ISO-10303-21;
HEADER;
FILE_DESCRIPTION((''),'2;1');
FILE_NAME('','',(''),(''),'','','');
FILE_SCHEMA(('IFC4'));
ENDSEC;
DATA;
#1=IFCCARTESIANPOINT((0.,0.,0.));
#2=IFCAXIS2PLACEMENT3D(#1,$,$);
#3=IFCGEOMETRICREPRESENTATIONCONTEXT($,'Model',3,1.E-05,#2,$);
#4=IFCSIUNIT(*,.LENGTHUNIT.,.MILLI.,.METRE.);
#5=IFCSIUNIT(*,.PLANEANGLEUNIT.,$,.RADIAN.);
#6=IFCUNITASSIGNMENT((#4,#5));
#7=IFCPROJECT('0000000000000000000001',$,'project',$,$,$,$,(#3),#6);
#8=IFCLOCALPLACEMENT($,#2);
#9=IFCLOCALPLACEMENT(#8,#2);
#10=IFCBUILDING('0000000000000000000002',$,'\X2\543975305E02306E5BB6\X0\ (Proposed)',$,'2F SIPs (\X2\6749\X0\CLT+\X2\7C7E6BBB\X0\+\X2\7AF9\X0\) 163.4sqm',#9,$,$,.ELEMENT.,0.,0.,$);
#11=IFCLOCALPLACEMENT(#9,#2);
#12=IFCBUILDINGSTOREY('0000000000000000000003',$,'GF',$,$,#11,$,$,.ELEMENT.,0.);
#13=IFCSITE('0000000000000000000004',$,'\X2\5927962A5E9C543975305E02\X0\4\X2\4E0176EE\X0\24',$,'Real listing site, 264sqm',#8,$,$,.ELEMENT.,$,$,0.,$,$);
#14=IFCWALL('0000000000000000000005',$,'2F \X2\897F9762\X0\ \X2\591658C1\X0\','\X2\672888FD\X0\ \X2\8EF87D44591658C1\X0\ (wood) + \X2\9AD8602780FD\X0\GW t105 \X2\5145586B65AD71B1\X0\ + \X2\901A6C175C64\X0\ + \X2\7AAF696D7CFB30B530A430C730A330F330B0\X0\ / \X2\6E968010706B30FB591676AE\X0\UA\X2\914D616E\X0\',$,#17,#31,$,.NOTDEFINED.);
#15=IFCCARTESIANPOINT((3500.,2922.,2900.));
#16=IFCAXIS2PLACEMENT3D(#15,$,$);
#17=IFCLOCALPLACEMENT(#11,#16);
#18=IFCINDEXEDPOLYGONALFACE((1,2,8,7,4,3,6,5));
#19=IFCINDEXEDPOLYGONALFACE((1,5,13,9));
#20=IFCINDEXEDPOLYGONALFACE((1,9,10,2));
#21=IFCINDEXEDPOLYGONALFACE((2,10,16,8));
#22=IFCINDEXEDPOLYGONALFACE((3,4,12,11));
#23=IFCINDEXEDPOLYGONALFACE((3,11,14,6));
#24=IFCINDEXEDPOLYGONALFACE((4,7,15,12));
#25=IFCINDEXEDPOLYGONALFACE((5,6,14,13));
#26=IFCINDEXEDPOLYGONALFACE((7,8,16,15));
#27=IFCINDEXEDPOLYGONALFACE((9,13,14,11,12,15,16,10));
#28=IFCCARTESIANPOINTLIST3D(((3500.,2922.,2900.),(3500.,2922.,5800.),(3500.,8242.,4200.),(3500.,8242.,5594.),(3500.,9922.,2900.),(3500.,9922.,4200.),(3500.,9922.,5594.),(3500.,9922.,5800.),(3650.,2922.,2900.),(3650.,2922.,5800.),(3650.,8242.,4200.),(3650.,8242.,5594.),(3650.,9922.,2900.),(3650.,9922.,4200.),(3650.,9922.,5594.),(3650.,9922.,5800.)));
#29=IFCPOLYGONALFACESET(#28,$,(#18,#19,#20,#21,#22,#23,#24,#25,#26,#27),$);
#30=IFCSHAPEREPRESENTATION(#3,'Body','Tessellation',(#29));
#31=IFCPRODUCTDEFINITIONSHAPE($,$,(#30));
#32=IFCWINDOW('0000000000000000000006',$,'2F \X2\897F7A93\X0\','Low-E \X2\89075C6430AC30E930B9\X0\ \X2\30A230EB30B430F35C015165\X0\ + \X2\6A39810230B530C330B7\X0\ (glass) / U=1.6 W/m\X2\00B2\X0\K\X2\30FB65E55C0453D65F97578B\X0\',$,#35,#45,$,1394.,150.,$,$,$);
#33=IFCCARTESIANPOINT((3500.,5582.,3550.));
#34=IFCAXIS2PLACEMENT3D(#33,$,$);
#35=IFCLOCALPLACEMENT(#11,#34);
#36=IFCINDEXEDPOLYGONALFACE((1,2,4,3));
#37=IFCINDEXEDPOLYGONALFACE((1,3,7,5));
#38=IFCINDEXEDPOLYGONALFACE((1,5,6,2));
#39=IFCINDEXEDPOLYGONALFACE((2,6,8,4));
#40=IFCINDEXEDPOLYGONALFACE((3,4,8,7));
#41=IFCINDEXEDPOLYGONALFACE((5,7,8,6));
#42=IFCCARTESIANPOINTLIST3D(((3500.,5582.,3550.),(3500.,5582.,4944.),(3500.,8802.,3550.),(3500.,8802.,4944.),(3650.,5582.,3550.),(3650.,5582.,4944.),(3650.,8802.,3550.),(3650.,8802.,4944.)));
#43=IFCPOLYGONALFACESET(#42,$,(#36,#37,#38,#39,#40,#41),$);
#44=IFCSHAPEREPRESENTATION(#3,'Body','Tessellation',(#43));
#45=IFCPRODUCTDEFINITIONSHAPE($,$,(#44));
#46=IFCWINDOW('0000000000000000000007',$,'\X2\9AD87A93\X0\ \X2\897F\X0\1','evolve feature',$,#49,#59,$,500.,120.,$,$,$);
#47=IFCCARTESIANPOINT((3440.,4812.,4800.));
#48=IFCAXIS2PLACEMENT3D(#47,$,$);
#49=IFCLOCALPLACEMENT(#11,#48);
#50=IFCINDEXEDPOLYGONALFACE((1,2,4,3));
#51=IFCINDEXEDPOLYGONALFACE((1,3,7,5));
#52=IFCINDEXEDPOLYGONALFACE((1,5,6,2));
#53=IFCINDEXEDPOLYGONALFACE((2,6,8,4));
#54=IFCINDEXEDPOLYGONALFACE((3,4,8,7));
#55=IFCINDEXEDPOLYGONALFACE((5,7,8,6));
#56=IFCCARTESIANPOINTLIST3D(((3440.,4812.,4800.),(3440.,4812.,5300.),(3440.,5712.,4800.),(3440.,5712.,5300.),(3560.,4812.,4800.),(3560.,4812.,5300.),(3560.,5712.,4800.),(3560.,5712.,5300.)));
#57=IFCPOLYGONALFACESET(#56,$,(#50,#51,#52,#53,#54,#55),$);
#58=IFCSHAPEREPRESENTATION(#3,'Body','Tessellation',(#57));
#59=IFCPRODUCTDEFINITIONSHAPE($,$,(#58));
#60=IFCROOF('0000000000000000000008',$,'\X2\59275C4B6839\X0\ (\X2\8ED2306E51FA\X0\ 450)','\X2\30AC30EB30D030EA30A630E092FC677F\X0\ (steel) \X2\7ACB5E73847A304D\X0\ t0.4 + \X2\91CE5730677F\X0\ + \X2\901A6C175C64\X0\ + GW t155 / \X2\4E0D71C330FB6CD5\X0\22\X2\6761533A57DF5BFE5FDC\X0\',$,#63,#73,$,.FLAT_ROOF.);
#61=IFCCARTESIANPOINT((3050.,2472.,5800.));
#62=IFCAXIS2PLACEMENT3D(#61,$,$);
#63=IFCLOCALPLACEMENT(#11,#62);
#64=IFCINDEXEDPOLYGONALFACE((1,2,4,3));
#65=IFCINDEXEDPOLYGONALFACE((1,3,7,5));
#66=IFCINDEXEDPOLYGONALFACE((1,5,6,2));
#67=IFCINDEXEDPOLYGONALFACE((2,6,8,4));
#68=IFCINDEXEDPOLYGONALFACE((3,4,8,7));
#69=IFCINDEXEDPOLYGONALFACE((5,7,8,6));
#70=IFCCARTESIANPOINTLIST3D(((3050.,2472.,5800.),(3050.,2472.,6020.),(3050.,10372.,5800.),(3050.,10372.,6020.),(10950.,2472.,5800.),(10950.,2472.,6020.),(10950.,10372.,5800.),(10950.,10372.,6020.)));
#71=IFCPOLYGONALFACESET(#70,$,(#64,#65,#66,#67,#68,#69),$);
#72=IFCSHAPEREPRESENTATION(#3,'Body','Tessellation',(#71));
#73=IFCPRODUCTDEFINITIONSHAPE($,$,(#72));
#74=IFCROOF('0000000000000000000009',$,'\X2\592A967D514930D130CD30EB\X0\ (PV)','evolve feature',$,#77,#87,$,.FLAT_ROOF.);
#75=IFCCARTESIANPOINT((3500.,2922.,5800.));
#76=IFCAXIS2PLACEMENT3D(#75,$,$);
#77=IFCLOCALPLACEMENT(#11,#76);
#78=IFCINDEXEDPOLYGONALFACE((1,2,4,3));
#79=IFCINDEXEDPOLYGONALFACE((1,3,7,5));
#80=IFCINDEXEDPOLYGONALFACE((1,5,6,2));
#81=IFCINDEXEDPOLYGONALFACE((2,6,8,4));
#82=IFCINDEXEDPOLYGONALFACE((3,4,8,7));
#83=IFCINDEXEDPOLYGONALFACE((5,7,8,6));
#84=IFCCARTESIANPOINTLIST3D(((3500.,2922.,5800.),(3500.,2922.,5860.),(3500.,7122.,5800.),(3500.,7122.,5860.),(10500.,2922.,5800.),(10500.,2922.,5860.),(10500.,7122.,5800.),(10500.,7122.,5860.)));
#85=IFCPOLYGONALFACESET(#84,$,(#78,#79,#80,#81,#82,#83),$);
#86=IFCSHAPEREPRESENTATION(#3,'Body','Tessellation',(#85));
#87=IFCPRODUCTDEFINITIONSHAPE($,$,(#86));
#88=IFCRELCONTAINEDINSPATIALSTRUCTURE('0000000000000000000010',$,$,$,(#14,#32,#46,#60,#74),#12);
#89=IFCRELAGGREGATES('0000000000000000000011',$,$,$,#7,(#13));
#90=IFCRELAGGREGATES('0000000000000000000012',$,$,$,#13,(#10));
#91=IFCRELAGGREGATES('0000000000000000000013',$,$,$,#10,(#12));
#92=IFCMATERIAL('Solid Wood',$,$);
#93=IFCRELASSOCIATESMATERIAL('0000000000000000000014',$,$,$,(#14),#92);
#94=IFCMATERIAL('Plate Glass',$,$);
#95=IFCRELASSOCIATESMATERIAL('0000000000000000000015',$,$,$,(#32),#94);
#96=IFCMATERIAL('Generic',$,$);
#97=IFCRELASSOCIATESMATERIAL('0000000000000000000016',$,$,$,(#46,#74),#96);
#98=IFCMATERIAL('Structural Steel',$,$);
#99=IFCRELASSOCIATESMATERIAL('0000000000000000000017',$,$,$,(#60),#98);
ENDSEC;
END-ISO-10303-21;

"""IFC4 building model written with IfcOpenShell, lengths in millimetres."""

from ifc_helpers import new_model, si_unit, frame, frame_2d, origin, place, context, project, spatial, rectangle, extrude, material, element, fill, save


model = new_model("IFC4")

# Units and contexts
model_context = context("Model", 3, precision=1e-05, world=origin())
ifc_project = project(units=[si_unit("LENGTHUNIT", "METRE", prefix="MILLI"), si_unit("PLANEANGLEUNIT", "RADIAN")], contexts=[model_context])

# Site, building, storey
site_placement = place(None, origin())
site = spatial("IfcSite", under=ifc_project, at=site_placement, Name="大阪府吹田市4丁目24", ObjectType="Real listing site, 264sqm", CompositionType="ELEMENT", RefElevation=0.0)
building_placement = place(site_placement, origin())
building = spatial("IfcBuilding", under=site, at=building_placement, Name="吹田市の家 (Proposed)", ObjectType="2F SIPs (杉CLT+籾殻+竹) 163.4sqm", CompositionType="ELEMENT", ElevationOfRefHeight=0.0, ElevationOfTerrain=0.0)
storey_placement = place(building_placement, origin())
storey = spatial("IfcBuildingStorey", under=building, at=storey_placement, Name="GF", CompositionType="ELEMENT", Elevation=0.0)

# Shared definitions
ifc_material_1 = material(Name="Solid Wood")
ifc_material_2 = material(Name="Generic")

# Shared definitions
ifc_material_3 = material(Name="Plate Glass")

# Wall, openings, windows
wall_1_placement = place(storey_placement, frame((3500.0, 2922.0, 2900.0)))
wall_1 = element("IfcWall", 1, at=wall_1_placement, inside=storey, material=ifc_material_1, Name="2F 西面 外壁", Description="木製 軸組外壁 (wood) + 高性能GW t105 充填断熱 + 通気層 + 窯業系サイディング / 準耐火・外皮UA配慮", PredefinedType="NOTDEFINED", context=model_context, shape_type="SweptSolid", body=[
    extrude(rectangle(XDim=150.0, YDim=7000.0, at=frame_2d((75.0, 3500.0))), frame((3500.0, 2922.0, 2900.0)), (0.0, 0.0, 1.0), 2900.0),
])
opening_1_placement = place(storey_placement, frame((3500.0, 5582.0, 3550.0)))
opening_1 = element("IfcOpeningElement", 2, at=opening_1_placement, cuts=wall_1, PredefinedType="NOTDEFINED", context=model_context, shape_type="SweptSolid", body=[
    extrude(rectangle(XDim=150.0, YDim=3220.0, at=frame_2d((75.0, 1610.0))), frame((3500.0, 5582.0, 3550.0)), (0.0, 0.0, 1.0), 1394.0),
])
opening_2_placement = place(storey_placement, frame((3440.0, 4812.0, 4800.0)))
opening_2 = element("IfcOpeningElement", 3, at=opening_2_placement, cuts=wall_1, PredefinedType="NOTDEFINED", context=model_context, shape_type="SweptSolid", body=[
    extrude(rectangle(XDim=120.0, YDim=900.0, at=frame_2d((60.0, 450.0))), frame((3440.0, 4812.0, 4800.0)), (0.0, 0.0, 1.0), 500.0),
])
window_1_placement = place(storey_placement, frame((3500.0, 5582.0, 3550.0)))
window_1 = element("IfcWindow", 4, at=window_1_placement, inside=storey, material=ifc_material_3, Name="2F 西窓", Description="Low-E 複層ガラス アルゴン封入 + 樹脂サッシ (glass) / U=1.6 W/m²K・日射取得型", OverallHeight=1394.0, OverallWidth=150.0, context=model_context, shape_type="SweptSolid", body=[
    extrude(rectangle(XDim=150.0, YDim=3220.0, at=frame_2d((75.0, 1610.0))), frame((3500.0, 5582.0, 3550.0)), (0.0, 0.0, 1.0), 1394.0),
])
fill(opening_1, window_1)
window_2_placement = place(storey_placement, frame((3440.0, 4812.0, 4800.0)))
window_2 = element("IfcWindow", 5, at=window_2_placement, inside=storey, material=ifc_material_2, Name="高窓 西1", Description="evolve feature", OverallHeight=500.0, OverallWidth=120.0, context=model_context, shape_type="SweptSolid", body=[
    extrude(rectangle(XDim=120.0, YDim=900.0, at=frame_2d((60.0, 450.0))), frame((3440.0, 4812.0, 4800.0)), (0.0, 0.0, 1.0), 500.0),
])
fill(opening_2, window_2)

# Roofs
ifc_material_4 = material(Name="Structural Steel")
roof_1_placement = place(storey_placement, frame((3050.0, 2472.0, 5800.0)))
element("IfcRoof", 6, at=roof_1_placement, inside=storey, material=ifc_material_4, Name="大屋根 (軒の出 450)", Description="ガルバリウム鋼板 (steel) 立平葺き t0.4 + 野地板 + 通気層 + GW t155 / 不燃・法22条区域対応", PredefinedType="FLAT_ROOF", context=model_context, shape_type="SweptSolid", body=[
    extrude(rectangle(XDim=7900.0, YDim=7900.0, at=frame_2d((3950.0, 3950.0))), frame((3050.0, 2472.0, 5800.0)), (0.0, 0.0, 1.0), 220.0),
])
roof_2_placement = place(storey_placement, frame((3500.0, 2922.0, 5800.0)))
element("IfcRoof", 7, at=roof_2_placement, inside=storey, material=ifc_material_2, Name="太陽光パネル (PV)", Description="evolve feature", PredefinedType="FLAT_ROOF", context=model_context, shape_type="SweptSolid", body=[
    extrude(rectangle(XDim=7000.0, YDim=4200.0, at=frame_2d((3500.0, 2100.0))), frame((3500.0, 2922.0, 5800.0)), (0.0, 0.0, 1.0), 60.0),
])

save(model, "model.ifc")
